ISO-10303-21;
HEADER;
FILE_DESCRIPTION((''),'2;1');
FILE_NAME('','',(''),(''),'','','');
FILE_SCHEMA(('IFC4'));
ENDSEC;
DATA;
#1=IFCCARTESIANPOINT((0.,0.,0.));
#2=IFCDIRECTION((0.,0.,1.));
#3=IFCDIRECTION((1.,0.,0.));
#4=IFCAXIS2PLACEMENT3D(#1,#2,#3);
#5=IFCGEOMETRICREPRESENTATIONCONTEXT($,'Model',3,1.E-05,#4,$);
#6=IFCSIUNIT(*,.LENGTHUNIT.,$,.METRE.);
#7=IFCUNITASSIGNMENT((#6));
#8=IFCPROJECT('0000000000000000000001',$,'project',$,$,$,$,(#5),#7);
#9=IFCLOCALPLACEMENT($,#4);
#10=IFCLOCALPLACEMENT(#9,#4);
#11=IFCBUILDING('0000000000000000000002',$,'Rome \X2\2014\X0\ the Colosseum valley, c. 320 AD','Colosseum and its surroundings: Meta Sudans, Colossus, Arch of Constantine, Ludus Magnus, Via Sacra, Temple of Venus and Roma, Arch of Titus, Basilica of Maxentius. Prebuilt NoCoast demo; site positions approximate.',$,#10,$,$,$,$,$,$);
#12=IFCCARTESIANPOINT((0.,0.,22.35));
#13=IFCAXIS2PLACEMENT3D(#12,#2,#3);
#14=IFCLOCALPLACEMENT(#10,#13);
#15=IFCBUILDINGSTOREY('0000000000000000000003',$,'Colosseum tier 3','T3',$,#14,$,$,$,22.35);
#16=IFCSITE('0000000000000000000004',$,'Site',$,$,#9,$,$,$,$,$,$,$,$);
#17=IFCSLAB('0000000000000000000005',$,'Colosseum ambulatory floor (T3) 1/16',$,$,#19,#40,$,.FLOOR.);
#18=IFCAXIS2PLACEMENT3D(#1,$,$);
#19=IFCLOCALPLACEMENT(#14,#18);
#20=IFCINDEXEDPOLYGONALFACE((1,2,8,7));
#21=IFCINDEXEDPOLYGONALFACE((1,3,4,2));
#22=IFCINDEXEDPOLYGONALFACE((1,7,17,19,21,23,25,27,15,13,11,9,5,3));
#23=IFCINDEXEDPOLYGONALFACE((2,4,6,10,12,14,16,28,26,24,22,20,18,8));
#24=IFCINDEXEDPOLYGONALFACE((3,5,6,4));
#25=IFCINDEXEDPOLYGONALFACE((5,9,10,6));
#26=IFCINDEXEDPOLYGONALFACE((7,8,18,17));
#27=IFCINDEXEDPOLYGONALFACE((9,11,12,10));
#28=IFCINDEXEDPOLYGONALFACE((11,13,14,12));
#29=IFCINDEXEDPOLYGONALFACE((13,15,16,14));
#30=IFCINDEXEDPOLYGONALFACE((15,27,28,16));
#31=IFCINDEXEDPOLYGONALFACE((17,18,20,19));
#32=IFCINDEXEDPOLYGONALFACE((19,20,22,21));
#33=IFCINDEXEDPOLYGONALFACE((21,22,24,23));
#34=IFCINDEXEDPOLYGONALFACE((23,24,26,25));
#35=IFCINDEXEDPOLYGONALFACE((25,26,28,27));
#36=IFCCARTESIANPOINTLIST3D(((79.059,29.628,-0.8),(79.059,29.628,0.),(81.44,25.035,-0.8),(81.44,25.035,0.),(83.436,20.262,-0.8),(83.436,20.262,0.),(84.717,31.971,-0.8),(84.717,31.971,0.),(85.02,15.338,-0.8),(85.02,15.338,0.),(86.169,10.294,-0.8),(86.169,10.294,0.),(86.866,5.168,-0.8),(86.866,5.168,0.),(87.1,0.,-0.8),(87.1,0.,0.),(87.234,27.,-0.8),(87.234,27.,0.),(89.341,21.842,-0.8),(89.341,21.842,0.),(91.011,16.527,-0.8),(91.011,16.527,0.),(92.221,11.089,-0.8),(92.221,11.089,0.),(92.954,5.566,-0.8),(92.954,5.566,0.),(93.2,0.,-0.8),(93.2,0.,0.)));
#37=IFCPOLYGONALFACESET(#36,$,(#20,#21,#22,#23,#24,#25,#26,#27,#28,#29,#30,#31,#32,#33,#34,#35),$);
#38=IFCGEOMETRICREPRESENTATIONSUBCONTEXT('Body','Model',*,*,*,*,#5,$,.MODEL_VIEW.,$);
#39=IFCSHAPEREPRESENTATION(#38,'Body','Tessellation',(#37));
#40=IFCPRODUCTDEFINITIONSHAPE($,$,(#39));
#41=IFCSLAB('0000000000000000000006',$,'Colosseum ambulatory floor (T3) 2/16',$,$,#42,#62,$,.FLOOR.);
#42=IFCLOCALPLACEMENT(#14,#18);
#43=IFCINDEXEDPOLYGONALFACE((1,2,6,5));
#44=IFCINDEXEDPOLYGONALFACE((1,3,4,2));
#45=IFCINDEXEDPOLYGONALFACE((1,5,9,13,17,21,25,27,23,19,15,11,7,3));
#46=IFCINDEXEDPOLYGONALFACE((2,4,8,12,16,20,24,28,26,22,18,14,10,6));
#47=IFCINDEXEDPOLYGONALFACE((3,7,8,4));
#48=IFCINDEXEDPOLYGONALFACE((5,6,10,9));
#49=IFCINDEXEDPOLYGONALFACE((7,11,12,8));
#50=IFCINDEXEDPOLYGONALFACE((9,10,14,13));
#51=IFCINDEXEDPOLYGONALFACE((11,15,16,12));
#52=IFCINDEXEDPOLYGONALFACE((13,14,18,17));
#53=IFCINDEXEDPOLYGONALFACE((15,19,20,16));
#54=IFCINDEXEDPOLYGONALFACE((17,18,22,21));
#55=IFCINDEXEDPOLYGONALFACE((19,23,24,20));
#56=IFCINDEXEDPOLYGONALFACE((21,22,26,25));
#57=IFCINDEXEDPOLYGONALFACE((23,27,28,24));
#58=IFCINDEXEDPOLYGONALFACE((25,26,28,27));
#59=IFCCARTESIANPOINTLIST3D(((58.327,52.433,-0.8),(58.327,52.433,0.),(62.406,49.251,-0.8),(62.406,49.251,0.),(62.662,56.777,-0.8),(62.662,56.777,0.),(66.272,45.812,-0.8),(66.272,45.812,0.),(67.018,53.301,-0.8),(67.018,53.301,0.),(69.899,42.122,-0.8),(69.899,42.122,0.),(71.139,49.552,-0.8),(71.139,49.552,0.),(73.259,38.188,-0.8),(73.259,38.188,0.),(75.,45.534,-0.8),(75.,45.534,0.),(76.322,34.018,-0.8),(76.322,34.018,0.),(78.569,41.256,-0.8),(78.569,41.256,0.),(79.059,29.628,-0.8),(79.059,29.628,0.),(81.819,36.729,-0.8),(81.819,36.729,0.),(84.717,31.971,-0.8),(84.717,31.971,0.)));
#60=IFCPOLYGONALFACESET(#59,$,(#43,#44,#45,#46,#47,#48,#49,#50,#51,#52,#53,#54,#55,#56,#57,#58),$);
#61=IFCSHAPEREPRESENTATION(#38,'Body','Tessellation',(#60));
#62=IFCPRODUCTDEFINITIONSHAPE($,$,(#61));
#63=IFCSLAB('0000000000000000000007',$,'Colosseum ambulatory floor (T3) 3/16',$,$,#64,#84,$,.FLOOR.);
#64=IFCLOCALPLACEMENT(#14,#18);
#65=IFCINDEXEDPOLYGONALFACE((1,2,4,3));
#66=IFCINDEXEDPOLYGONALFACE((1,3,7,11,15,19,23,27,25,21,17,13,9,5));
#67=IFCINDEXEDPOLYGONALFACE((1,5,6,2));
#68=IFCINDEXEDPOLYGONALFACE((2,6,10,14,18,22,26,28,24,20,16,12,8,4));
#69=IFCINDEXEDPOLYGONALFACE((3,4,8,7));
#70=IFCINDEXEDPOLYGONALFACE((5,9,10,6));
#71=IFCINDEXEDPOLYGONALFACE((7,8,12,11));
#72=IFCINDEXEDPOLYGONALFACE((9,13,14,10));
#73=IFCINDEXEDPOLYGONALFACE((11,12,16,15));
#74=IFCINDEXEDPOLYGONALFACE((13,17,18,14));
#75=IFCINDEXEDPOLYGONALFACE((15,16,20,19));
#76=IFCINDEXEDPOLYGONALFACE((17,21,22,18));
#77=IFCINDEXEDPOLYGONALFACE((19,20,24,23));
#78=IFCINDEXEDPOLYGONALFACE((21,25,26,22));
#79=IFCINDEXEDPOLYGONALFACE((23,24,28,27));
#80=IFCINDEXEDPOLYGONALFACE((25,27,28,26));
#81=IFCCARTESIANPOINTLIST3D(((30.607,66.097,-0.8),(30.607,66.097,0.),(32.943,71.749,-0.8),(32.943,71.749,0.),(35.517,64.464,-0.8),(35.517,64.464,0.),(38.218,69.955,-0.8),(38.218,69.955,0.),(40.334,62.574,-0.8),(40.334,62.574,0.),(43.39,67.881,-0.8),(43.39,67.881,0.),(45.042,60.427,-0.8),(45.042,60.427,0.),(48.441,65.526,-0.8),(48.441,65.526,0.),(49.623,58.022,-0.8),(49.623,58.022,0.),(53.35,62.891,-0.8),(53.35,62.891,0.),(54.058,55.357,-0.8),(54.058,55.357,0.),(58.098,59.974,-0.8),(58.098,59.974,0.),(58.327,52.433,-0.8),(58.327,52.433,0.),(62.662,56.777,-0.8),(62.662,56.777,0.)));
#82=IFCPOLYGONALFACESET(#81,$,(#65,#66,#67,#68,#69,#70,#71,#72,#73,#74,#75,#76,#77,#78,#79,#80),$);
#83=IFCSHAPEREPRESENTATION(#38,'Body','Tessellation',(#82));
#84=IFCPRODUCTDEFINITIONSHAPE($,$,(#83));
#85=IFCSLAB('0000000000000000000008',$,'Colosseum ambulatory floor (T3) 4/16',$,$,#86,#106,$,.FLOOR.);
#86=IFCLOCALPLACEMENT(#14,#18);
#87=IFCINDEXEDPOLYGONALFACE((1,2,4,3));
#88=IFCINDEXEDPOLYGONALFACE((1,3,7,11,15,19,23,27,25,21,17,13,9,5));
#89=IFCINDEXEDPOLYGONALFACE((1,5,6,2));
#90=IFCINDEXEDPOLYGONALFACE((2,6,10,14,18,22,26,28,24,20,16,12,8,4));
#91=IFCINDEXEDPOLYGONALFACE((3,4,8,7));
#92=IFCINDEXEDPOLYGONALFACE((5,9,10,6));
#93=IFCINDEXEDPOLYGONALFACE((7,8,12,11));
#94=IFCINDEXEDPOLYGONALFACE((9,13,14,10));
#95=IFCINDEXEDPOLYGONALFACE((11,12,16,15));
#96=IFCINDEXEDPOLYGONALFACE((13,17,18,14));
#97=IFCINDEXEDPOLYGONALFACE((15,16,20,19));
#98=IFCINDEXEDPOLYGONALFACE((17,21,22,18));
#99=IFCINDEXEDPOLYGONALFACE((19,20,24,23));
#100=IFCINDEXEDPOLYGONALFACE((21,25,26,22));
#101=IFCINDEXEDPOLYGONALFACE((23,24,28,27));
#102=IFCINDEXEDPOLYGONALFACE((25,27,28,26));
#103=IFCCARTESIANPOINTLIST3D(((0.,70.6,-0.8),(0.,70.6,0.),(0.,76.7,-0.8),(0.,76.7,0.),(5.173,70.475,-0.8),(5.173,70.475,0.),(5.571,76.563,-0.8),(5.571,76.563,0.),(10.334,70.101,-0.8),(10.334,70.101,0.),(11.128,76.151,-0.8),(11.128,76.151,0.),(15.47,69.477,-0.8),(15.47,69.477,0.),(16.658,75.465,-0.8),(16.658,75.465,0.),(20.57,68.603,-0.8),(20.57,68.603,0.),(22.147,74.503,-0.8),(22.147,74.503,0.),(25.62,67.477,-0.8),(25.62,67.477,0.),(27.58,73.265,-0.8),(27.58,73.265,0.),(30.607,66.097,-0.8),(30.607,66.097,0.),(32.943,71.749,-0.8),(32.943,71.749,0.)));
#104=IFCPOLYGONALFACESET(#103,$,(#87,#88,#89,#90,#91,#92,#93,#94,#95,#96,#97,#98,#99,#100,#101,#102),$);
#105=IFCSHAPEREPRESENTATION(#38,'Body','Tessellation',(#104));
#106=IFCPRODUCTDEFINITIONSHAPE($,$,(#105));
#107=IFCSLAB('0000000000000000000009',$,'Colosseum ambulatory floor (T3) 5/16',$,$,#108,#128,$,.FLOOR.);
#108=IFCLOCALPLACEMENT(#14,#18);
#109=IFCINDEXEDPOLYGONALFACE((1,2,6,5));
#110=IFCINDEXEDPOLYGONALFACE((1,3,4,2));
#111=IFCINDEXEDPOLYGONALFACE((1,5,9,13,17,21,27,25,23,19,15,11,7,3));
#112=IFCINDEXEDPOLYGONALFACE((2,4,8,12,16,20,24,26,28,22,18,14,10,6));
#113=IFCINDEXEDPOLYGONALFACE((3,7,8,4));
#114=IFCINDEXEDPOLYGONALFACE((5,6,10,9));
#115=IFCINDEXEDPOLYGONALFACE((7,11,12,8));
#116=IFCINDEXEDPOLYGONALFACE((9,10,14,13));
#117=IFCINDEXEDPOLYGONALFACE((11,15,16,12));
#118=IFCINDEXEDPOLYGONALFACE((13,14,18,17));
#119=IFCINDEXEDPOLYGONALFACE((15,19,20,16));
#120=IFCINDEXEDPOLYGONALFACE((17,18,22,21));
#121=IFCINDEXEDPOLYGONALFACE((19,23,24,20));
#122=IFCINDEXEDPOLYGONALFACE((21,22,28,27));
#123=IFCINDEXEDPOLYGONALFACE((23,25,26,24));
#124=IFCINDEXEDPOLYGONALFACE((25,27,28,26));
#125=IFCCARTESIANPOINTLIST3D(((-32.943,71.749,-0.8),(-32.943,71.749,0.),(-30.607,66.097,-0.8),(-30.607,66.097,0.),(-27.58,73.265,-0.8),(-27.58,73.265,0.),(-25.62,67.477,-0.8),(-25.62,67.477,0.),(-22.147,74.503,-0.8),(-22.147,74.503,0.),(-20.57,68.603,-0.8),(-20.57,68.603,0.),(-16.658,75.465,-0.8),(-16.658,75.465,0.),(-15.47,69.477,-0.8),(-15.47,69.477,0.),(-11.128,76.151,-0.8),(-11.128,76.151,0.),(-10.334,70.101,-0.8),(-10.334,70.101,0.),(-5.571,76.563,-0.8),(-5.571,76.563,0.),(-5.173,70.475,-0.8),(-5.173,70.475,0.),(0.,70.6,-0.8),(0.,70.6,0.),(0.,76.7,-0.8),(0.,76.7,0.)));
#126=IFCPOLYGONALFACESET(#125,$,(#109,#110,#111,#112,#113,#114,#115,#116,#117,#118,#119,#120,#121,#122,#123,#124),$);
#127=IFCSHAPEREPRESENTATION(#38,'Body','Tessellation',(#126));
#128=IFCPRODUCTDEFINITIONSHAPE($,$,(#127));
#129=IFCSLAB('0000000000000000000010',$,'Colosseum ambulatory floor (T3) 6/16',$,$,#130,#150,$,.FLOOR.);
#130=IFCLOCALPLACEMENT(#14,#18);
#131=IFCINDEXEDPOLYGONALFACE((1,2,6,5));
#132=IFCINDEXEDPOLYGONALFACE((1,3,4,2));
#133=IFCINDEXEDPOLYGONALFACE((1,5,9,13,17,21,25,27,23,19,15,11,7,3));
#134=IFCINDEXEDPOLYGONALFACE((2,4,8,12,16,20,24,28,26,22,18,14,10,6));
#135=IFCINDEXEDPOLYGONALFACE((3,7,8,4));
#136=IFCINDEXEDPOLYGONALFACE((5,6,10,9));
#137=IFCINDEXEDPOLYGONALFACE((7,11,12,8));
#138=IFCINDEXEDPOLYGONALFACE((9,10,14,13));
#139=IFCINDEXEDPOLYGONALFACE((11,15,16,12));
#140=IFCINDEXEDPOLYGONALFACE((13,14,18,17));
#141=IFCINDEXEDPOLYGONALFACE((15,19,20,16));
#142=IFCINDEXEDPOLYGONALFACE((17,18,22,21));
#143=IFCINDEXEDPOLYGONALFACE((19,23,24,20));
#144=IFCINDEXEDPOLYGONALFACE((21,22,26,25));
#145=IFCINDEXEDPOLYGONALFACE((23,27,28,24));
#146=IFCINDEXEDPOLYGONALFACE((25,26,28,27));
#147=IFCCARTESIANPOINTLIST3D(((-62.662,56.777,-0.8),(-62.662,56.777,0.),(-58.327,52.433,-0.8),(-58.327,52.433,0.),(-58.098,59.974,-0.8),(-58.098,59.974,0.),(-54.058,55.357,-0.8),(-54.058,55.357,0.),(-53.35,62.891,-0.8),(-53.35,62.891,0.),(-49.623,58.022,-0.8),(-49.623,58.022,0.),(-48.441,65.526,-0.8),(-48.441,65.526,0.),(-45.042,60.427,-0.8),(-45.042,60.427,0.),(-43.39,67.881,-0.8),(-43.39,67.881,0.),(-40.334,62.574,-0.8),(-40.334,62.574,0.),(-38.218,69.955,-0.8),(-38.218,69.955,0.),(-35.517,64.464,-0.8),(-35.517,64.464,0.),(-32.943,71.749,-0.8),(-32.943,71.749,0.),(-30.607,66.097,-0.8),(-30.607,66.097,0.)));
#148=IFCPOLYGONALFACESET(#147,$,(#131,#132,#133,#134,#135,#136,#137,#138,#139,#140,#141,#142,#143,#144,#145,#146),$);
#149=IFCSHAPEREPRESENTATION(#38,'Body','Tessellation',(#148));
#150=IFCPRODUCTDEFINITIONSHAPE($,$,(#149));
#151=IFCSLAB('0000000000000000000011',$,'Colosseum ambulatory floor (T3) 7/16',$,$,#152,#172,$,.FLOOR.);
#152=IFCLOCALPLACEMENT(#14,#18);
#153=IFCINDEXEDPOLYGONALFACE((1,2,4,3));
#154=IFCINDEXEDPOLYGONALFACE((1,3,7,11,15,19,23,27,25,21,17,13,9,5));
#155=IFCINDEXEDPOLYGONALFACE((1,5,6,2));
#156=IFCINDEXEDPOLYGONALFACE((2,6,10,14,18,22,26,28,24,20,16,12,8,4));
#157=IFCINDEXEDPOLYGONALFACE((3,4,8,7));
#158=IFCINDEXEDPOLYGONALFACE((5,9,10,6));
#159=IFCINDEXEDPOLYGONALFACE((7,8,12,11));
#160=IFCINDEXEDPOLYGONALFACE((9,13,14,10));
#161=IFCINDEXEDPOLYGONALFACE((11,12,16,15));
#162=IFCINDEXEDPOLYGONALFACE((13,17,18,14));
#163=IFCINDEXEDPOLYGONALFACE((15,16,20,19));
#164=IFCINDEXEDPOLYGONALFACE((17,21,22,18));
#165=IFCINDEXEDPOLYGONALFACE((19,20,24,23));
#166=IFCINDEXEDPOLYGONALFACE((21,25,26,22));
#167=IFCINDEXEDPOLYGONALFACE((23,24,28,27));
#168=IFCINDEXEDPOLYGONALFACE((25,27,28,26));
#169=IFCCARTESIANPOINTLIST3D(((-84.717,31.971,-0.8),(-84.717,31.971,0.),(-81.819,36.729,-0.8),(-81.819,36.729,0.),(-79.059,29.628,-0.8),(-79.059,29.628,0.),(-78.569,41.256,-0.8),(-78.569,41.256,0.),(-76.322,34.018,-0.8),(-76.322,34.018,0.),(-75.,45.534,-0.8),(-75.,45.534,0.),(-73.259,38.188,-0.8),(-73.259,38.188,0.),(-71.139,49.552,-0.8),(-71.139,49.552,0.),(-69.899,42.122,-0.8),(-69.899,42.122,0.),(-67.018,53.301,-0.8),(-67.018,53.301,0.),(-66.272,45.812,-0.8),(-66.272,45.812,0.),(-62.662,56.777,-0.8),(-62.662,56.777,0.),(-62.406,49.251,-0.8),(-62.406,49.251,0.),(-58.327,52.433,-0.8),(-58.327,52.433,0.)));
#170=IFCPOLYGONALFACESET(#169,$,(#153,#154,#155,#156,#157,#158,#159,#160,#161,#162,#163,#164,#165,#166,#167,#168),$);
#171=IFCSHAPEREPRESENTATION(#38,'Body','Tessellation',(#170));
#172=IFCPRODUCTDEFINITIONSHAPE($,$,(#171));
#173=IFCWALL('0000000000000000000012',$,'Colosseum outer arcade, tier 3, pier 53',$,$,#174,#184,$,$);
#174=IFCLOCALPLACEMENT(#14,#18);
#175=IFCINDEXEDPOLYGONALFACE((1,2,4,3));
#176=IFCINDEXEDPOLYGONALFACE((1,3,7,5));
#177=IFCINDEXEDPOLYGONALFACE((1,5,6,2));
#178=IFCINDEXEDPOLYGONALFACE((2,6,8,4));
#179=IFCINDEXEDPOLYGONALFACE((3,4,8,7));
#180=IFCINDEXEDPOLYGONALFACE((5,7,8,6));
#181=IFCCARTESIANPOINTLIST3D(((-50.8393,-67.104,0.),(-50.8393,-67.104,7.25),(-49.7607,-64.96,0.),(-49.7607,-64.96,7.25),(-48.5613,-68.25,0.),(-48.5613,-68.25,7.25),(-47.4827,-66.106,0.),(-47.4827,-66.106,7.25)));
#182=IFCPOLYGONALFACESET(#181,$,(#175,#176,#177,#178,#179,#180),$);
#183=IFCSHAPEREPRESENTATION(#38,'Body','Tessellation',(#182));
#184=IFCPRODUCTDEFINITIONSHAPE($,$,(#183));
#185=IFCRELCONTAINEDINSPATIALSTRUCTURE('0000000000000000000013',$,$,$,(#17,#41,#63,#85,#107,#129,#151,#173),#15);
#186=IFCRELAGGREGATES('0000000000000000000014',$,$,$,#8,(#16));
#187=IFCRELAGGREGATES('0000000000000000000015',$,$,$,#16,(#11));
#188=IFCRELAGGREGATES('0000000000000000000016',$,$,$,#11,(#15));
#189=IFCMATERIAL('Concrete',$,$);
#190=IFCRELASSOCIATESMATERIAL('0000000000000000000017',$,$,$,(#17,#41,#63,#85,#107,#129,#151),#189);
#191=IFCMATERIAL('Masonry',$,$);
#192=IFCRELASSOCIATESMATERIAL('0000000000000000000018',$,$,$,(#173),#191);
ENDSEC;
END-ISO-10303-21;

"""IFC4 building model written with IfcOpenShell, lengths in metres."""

from ifc_helpers import new_model, si_unit, frame, origin_with_axes, place, context, subcontext, project, spatial, indexed_curve, outline, extrude, material, element, save


model = new_model("IFC4")

# Units and contexts
model_context = context("Model", 3, precision=1e-05, world=origin_with_axes())
body_context = subcontext(model_context, "Body", "Model", "MODEL_VIEW")
ifc_project = project(units=[si_unit("LENGTHUNIT", "METRE")], contexts=[model_context])

# Site, building, storey
site_placement = place(None, origin_with_axes())
site = spatial("IfcSite", under=ifc_project, at=site_placement, Name="Site")
building_placement = place(site_placement, origin_with_axes())
building = spatial("IfcBuilding", under=site, at=building_placement, Name="Rome — the Colosseum valley, c. 320 AD", Description="Colosseum and its surroundings: Meta Sudans, Colossus, Arch of Constantine, Ludus Magnus, Via Sacra, Temple of Venus and Roma, Arch of Titus, Basilica of Maxentius. Prebuilt NoCoast demo; site positions approximate.")
storey_placement = place(building_placement, frame((0.0, 0.0, 22.35), z_axis=(0.0, 0.0, 1.0), x_axis=(1.0, 0.0, 0.0)))
storey = spatial("IfcBuildingStorey", under=building, at=storey_placement, Name="Colosseum tier 3", Description="T3", Elevation=22.35)

# Slabs
ifc_material_1 = material(Name="Concrete")
slab_1_placement = place(storey_placement, frame((0.0, 0.0, -0.8), z_axis=(0.0, 0.0, 1.0), x_axis=(1.0, 0.0, 0.0)))
element("IfcSlab", 1, at=slab_1_placement, inside=storey, material=ifc_material_1, Name="Colosseum ambulatory floor (T3) 1/16", PredefinedType="FLOOR", context=body_context, shape_type="SweptSolid", body=[
    extrude(outline(indexed_curve([(87.1, 0.0), (86.866, 5.168), (86.169, 10.294), (85.02, 15.338), (83.436, 20.262), (81.44, 25.035), (79.059, 29.628), (84.717, 31.971), (87.234, 27.0), (89.341, 21.842), (91.011, 16.527), (92.221, 11.089), (92.954, 5.566), (93.2, 0.0)])), None, (0.0, 0.0, 1.0), 0.8),
])
slab_2_placement = place(storey_placement, frame((0.0, 0.0, -0.8), z_axis=(0.0, 0.0, 1.0), x_axis=(1.0, 0.0, 0.0)))
element("IfcSlab", 2, at=slab_2_placement, inside=storey, material=ifc_material_1, Name="Colosseum ambulatory floor (T3) 2/16", PredefinedType="FLOOR", context=body_context, shape_type="SweptSolid", body=[
    extrude(outline(indexed_curve([(79.059, 29.628), (76.322, 34.018), (73.259, 38.188), (69.899, 42.122), (66.272, 45.812), (62.406, 49.251), (58.327, 52.433), (62.662, 56.777), (67.018, 53.301), (71.139, 49.552), (75.0, 45.534), (78.569, 41.256), (81.819, 36.729), (84.717, 31.971)])), None, (0.0, 0.0, 1.0), 0.8),
])
slab_3_placement = place(storey_placement, frame((0.0, 0.0, -0.8), z_axis=(0.0, 0.0, 1.0), x_axis=(1.0, 0.0, 0.0)))
element("IfcSlab", 3, at=slab_3_placement, inside=storey, material=ifc_material_1, Name="Colosseum ambulatory floor (T3) 3/16", PredefinedType="FLOOR", context=body_context, shape_type="SweptSolid", body=[
    extrude(outline(indexed_curve([(58.327, 52.433), (54.058, 55.357), (49.623, 58.022), (45.042, 60.427), (40.334, 62.574), (35.517, 64.464), (30.607, 66.097), (32.943, 71.749), (38.218, 69.955), (43.39, 67.881), (48.441, 65.526), (53.35, 62.891), (58.098, 59.974), (62.662, 56.777)])), None, (0.0, 0.0, 1.0), 0.8),
])
slab_4_placement = place(storey_placement, frame((0.0, 0.0, -0.8), z_axis=(0.0, 0.0, 1.0), x_axis=(1.0, 0.0, 0.0)))
element("IfcSlab", 4, at=slab_4_placement, inside=storey, material=ifc_material_1, Name="Colosseum ambulatory floor (T3) 4/16", PredefinedType="FLOOR", context=body_context, shape_type="SweptSolid", body=[
    extrude(outline(indexed_curve([(30.607, 66.097), (25.62, 67.477), (20.57, 68.603), (15.47, 69.477), (10.334, 70.101), (5.173, 70.475), (0.0, 70.6), (0.0, 76.7), (5.571, 76.563), (11.128, 76.151), (16.658, 75.465), (22.147, 74.503), (27.58, 73.265), (32.943, 71.749)])), None, (0.0, 0.0, 1.0), 0.8),
])
slab_5_placement = place(storey_placement, frame((0.0, 0.0, -0.8), z_axis=(0.0, 0.0, 1.0), x_axis=(1.0, 0.0, 0.0)))
element("IfcSlab", 5, at=slab_5_placement, inside=storey, material=ifc_material_1, Name="Colosseum ambulatory floor (T3) 5/16", PredefinedType="FLOOR", context=body_context, shape_type="SweptSolid", body=[
    extrude(outline(indexed_curve([(0.0, 70.6), (-5.173, 70.475), (-10.334, 70.101), (-15.47, 69.477), (-20.57, 68.603), (-25.62, 67.477), (-30.607, 66.097), (-32.943, 71.749), (-27.58, 73.265), (-22.147, 74.503), (-16.658, 75.465), (-11.128, 76.151), (-5.571, 76.563), (0.0, 76.7)])), None, (0.0, 0.0, 1.0), 0.8),
])
slab_6_placement = place(storey_placement, frame((0.0, 0.0, -0.8), z_axis=(0.0, 0.0, 1.0), x_axis=(1.0, 0.0, 0.0)))
element("IfcSlab", 6, at=slab_6_placement, inside=storey, material=ifc_material_1, Name="Colosseum ambulatory floor (T3) 6/16", PredefinedType="FLOOR", context=body_context, shape_type="SweptSolid", body=[
    extrude(outline(indexed_curve([(-30.607, 66.097), (-35.517, 64.464), (-40.334, 62.574), (-45.042, 60.427), (-49.623, 58.022), (-54.058, 55.357), (-58.327, 52.433), (-62.662, 56.777), (-58.098, 59.974), (-53.35, 62.891), (-48.441, 65.526), (-43.39, 67.881), (-38.218, 69.955), (-32.943, 71.749)])), None, (0.0, 0.0, 1.0), 0.8),
])
slab_7_placement = place(storey_placement, frame((0.0, 0.0, -0.8), z_axis=(0.0, 0.0, 1.0), x_axis=(1.0, 0.0, 0.0)))
element("IfcSlab", 7, at=slab_7_placement, inside=storey, material=ifc_material_1, Name="Colosseum ambulatory floor (T3) 7/16", PredefinedType="FLOOR", context=body_context, shape_type="SweptSolid", body=[
    extrude(outline(indexed_curve([(-58.327, 52.433), (-62.406, 49.251), (-66.272, 45.812), (-69.899, 42.122), (-73.259, 38.188), (-76.322, 34.018), (-79.059, 29.628), (-84.717, 31.971), (-81.819, 36.729), (-78.569, 41.256), (-75.0, 45.534), (-71.139, 49.552), (-67.018, 53.301), (-62.662, 56.777)])), None, (0.0, 0.0, 1.0), 0.8),
])

# Wall
ifc_material_2 = material(Name="Masonry")
wall_1_placement = place(storey_placement, frame((-50.3, -66.032, 0.0), z_axis=(0.0, 0.0, 1.0), x_axis=(0.893326, -0.449408, 0.0)))
element("IfcWall", 8, at=wall_1_placement, inside=storey, material=ifc_material_2, Name="Colosseum outer arcade, tier 3, pier 53", context=body_context, shape_type="SweptSolid", body=[
    extrude(outline(indexed_curve([(0.0, 0.0), (0.0, 2.4), (2.55, 2.4), (2.55, 0.0), (0.0, 0.0)], self_intersect=False)), frame((0.0, -1.2, 0.0), z_axis=(0.0, 0.0, 1.0), x_axis=(1.0, 0.0, 0.0)), (0.0, 0.0, 1.0), 7.25),
])

save(model, "model.ifc")
